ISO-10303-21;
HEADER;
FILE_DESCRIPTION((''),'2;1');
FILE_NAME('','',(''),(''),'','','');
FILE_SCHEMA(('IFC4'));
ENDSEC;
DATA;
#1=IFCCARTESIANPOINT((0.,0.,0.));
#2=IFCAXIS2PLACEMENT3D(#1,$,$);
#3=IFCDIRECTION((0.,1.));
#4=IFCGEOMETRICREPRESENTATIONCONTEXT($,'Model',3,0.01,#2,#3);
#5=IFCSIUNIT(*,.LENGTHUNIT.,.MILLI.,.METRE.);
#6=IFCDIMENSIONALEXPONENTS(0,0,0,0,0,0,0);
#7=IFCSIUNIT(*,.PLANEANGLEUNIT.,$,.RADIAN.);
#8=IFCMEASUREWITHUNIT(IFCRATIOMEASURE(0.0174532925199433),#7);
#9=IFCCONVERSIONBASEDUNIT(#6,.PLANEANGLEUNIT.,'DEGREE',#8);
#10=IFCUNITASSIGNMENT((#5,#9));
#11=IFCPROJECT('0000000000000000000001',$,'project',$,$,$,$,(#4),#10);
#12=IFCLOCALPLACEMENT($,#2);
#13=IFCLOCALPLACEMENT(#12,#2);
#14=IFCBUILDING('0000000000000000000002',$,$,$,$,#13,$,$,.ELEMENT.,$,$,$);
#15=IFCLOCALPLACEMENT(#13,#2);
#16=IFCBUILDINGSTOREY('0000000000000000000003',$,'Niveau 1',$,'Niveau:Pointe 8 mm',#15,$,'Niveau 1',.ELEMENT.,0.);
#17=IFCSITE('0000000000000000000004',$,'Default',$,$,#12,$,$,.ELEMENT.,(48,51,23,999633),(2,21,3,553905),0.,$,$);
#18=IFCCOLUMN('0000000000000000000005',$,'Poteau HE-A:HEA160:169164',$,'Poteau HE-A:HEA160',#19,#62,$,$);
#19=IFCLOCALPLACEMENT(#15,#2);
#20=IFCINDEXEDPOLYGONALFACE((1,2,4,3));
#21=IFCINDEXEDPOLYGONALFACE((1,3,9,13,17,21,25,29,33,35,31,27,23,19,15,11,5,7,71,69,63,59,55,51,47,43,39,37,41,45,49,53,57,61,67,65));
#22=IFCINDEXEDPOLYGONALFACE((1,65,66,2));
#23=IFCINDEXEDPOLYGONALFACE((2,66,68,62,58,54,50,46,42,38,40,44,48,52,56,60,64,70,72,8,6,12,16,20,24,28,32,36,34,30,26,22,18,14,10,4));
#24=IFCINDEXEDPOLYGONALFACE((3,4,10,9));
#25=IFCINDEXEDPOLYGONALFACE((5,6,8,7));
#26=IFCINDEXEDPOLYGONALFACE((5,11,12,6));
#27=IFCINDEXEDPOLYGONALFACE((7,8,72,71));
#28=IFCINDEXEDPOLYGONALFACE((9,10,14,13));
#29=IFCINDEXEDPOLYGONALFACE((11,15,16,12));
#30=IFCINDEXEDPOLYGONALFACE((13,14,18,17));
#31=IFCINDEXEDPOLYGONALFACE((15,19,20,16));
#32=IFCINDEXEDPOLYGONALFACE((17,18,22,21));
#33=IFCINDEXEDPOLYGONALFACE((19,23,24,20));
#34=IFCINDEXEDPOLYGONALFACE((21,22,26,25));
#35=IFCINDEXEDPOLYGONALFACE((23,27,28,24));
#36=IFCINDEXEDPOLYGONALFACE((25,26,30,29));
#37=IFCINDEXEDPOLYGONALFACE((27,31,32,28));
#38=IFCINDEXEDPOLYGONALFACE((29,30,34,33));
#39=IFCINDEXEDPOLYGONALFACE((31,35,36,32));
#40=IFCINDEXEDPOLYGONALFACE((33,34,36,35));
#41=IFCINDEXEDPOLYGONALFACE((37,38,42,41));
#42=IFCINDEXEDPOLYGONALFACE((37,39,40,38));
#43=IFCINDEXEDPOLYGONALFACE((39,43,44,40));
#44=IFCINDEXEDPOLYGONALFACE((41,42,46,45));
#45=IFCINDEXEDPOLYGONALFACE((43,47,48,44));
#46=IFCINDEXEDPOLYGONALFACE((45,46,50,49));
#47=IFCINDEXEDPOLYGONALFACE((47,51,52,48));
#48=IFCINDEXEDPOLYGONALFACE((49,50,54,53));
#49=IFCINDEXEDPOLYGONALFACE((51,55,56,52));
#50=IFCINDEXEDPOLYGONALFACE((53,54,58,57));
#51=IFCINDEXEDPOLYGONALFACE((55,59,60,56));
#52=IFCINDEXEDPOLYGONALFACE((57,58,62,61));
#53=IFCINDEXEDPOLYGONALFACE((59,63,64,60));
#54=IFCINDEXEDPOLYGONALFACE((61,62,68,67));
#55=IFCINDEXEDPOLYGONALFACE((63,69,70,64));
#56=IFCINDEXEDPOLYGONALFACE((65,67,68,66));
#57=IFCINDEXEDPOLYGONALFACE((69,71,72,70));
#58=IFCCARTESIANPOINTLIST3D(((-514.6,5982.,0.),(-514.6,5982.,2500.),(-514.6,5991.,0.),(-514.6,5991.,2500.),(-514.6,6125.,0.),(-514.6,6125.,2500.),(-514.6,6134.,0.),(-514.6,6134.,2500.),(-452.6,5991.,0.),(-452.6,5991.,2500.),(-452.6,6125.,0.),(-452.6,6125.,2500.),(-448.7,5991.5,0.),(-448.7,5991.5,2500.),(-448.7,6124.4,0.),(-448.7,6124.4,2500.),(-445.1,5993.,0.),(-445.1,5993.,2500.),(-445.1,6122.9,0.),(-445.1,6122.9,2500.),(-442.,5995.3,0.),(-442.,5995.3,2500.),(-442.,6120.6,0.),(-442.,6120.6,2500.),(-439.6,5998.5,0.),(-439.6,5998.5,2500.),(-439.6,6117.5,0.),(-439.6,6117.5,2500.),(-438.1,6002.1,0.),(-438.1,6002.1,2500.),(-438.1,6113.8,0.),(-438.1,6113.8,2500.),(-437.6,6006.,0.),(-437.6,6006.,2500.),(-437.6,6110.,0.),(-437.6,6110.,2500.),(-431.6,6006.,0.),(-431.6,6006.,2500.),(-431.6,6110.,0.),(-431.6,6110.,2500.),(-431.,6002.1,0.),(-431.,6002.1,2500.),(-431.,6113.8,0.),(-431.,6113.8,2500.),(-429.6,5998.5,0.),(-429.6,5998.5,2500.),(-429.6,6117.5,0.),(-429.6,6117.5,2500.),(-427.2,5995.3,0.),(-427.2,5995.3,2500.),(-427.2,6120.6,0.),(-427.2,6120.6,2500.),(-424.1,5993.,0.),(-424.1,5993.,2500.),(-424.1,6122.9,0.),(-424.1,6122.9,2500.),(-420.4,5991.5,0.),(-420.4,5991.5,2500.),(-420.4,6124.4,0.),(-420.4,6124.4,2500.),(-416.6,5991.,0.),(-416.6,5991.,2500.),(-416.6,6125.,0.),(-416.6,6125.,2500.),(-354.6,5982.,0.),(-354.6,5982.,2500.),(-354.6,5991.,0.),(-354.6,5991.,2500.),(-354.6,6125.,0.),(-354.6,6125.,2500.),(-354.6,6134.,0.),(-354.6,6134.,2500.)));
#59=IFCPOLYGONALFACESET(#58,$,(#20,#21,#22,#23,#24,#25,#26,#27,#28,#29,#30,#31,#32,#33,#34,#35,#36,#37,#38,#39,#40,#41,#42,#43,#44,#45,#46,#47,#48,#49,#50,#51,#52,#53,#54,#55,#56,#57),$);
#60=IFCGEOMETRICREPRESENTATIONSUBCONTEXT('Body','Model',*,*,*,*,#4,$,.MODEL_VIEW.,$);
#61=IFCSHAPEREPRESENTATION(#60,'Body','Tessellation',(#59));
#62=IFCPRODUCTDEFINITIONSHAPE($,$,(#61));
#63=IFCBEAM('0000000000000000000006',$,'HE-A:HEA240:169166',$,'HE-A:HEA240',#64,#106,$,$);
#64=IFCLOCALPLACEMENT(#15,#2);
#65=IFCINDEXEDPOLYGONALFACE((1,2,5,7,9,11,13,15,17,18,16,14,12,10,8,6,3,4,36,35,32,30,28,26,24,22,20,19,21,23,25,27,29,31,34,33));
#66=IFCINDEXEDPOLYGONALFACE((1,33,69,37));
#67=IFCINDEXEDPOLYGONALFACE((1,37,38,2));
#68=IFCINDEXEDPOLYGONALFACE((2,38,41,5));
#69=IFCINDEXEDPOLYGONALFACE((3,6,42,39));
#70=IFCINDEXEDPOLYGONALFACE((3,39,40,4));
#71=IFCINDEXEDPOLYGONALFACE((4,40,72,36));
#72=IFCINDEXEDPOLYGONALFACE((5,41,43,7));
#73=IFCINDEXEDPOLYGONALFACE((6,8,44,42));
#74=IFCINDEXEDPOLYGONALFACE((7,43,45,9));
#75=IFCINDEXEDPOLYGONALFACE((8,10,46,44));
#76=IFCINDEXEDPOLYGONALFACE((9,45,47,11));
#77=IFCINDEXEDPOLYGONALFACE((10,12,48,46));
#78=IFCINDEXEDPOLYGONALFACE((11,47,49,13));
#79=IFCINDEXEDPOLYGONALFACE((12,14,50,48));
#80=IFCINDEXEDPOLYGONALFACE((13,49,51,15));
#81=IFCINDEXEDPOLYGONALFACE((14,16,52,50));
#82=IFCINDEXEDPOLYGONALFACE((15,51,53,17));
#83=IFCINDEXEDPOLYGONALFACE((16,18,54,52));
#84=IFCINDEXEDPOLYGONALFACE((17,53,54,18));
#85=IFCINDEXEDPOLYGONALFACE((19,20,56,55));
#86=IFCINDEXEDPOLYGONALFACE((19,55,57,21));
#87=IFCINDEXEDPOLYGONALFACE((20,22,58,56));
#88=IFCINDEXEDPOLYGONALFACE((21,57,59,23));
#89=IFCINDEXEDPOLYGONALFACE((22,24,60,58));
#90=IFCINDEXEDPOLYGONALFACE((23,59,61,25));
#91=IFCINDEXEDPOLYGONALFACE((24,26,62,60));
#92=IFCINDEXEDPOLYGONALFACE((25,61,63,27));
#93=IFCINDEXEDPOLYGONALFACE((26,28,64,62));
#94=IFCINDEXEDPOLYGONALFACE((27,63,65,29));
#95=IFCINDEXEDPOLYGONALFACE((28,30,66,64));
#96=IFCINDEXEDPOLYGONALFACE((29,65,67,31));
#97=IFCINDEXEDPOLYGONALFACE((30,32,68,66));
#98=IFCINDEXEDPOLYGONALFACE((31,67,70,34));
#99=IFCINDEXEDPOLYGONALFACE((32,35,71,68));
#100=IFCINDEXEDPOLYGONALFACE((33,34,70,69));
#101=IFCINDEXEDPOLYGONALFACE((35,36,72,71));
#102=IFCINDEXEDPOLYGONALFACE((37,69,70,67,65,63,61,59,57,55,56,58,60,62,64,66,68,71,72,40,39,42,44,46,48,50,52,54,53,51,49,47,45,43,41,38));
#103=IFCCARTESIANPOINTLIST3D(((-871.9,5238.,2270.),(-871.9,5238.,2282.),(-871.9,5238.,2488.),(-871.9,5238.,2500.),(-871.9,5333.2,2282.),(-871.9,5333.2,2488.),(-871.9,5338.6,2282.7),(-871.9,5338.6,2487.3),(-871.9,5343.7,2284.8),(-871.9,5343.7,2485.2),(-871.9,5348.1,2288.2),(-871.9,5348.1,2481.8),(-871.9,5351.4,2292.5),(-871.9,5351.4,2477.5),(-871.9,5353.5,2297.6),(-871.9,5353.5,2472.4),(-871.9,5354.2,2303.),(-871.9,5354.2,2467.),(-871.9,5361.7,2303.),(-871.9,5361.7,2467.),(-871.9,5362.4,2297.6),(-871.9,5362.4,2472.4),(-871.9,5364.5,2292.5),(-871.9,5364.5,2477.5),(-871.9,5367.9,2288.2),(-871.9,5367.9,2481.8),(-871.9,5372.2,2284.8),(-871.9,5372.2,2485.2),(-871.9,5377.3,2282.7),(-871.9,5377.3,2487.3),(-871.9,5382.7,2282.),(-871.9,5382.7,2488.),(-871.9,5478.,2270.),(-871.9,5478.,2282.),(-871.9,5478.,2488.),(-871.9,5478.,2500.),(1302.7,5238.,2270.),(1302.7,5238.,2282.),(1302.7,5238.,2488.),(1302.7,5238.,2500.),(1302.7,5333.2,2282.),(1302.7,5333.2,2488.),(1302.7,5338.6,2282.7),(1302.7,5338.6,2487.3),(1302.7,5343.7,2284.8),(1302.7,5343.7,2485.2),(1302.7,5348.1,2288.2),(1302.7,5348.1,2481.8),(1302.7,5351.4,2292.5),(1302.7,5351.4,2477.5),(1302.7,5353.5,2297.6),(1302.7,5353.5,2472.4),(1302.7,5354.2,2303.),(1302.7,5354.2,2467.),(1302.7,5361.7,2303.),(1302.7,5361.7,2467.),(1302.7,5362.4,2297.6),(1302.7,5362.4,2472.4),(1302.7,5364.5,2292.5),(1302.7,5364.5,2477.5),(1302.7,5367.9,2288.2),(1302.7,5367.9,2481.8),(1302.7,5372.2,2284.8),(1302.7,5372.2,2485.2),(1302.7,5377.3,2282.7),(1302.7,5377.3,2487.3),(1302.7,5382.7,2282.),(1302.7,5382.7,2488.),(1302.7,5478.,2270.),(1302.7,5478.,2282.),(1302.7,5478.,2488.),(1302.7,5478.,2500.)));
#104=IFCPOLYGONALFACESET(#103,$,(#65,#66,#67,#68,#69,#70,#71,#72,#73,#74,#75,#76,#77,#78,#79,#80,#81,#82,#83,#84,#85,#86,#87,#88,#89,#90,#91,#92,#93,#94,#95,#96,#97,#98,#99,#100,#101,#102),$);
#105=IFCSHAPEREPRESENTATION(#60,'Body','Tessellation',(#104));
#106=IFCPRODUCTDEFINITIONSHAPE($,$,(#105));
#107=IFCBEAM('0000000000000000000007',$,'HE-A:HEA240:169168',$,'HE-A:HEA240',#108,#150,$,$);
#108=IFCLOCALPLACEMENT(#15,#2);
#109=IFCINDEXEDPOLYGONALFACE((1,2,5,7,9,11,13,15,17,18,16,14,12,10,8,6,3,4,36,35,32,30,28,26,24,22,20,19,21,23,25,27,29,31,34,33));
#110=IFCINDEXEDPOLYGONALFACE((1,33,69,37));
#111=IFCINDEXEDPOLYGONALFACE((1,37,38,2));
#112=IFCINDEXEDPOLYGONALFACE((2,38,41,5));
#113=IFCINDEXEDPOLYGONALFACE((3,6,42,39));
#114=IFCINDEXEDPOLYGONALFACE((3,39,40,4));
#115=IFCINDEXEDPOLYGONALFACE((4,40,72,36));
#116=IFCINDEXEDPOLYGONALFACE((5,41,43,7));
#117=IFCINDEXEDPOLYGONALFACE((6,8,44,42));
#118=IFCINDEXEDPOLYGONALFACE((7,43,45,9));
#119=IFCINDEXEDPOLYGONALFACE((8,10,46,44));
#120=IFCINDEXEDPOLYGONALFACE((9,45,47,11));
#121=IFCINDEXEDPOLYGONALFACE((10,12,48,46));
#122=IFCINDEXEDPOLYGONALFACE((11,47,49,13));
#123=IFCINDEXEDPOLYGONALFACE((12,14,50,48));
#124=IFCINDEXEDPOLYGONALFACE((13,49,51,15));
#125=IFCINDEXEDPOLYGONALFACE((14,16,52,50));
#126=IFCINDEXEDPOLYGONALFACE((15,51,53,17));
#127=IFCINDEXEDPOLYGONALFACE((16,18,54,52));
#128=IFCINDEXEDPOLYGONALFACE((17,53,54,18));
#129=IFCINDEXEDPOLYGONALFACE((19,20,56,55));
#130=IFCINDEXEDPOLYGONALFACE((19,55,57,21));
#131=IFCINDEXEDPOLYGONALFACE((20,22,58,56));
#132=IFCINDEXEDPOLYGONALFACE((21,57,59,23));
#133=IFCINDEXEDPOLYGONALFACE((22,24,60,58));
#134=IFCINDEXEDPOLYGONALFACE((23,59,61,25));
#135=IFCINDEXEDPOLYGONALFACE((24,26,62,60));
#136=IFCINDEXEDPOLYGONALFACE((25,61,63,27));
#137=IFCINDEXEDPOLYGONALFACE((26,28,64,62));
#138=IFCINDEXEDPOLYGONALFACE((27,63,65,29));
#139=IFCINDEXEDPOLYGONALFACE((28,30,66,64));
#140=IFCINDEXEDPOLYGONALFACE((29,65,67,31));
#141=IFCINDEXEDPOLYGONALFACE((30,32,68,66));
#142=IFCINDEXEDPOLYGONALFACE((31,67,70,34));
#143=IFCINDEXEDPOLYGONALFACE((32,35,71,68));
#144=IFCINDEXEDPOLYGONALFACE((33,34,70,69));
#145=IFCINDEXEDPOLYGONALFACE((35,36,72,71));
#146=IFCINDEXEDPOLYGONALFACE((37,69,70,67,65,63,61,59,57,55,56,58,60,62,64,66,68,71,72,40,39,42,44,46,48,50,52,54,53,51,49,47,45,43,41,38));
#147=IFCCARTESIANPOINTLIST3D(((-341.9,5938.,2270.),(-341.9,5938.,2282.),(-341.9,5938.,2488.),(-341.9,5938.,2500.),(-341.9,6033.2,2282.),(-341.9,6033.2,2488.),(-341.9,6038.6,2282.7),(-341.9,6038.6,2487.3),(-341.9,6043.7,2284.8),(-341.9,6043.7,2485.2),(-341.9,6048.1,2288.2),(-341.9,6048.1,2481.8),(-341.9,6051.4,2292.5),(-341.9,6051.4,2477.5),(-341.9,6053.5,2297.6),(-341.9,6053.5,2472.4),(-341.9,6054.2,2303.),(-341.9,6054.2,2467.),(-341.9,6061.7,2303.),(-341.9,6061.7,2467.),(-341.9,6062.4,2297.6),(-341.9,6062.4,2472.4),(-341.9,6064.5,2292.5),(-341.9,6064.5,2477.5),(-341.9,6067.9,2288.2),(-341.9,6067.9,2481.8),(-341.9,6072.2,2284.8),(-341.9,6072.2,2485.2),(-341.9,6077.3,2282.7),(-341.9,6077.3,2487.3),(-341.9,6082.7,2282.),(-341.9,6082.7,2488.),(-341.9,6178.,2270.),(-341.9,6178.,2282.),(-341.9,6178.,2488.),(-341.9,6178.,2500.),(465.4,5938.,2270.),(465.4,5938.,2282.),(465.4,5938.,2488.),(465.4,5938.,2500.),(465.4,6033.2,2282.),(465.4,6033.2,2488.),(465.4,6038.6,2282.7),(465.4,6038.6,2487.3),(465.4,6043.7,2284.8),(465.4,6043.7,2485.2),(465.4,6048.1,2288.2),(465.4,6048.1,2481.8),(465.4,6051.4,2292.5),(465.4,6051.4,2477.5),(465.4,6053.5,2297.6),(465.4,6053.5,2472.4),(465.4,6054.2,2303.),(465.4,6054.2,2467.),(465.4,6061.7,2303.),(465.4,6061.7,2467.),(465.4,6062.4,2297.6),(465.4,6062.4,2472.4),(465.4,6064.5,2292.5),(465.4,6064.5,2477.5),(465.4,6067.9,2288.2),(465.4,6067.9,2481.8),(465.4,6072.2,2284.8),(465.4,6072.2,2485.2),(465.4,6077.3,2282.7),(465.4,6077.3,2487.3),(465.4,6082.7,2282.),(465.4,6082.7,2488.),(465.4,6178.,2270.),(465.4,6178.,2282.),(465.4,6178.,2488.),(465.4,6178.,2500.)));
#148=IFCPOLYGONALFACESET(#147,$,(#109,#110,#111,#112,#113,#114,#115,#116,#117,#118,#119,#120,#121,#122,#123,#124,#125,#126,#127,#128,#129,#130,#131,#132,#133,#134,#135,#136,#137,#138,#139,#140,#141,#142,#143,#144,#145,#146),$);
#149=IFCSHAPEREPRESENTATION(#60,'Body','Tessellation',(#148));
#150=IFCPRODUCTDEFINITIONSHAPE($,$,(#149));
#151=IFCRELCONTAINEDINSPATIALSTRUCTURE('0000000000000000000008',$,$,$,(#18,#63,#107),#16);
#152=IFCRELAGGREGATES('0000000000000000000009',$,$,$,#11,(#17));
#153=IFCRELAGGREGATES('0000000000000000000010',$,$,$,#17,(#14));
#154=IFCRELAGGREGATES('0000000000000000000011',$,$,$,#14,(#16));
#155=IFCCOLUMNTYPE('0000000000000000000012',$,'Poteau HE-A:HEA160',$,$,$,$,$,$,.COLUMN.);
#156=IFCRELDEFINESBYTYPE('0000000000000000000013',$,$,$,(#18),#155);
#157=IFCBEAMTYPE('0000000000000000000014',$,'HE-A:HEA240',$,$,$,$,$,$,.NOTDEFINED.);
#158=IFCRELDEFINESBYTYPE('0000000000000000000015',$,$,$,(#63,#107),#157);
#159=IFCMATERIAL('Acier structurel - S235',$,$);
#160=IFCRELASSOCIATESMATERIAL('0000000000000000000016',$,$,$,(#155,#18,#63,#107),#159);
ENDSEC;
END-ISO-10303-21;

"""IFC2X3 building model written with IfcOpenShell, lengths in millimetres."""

from ifc_helpers import new_model, entity, si_unit, converted_unit, direction, frame, frame_2d, origin, place, context, subcontext, project, spatial, polyline, circle_curve, parameter, trimmed, segment, composite_curve, i_section, outline, extrude, source, transform, mapped, material, type_object, type_shapes, element, save


model = new_model("IFC2X3")

# Units and contexts
model_context = context("Model", 3, precision=0.01, world=origin(), true_north=direction((0.0, 1.0)))
body_context = subcontext(model_context, "Body", "Model", "MODEL_VIEW")
ifc_project = project(units=[si_unit("LENGTHUNIT", "METRE", prefix="MILLI"), converted_unit("PLANEANGLEUNIT", "DEGREE", entity("IfcRatioMeasure", 0.0174532925199433), si_unit("PLANEANGLEUNIT", "RADIAN"), dimensions=[0, 0, 0, 0, 0, 0, 0])], contexts=[model_context])

# Site, building, storey
site_placement = place(None, origin())
site = spatial("IfcSite", under=ifc_project, at=site_placement, Name="Default", CompositionType="ELEMENT", RefLatitude=(48, 51, 23, 999633), RefLongitude=(2, 21, 3, 553905), RefElevation=0.0)
building_placement = place(site_placement, origin())
building = spatial("IfcBuilding", under=site, at=building_placement, CompositionType="ELEMENT")
storey_placement = place(building_placement, origin())
storey = spatial("IfcBuildingStorey", under=building, at=storey_placement, Name="Niveau 1", ObjectType="Niveau:Pointe 8 mm", LongName="Niveau 1", CompositionType="ELEMENT", Elevation=0.0)

# Column
ifc_material_1 = material(Name="Acier structurel - S235")
column_type_1 = type_object("IfcColumnType", Name="Poteau HE-A:HEA160", PredefinedType="COLUMN", material=ifc_material_1)
shared_shape_1 = source(origin(), body_context, "Body", "SweptSolid", [
    extrude(outline(composite_curve([segment(polyline([(67.0, -80.0), (76.0, -80.0)]), True, "CONTINUOUS"), segment(polyline([(76.0, -80.0), (76.0, 80.0)]), True, "CONTINUOUS"), segment(polyline([(76.0, 80.0), (67.0, 80.0)]), True, "CONTINUOUS"), segment(polyline([(67.0, 80.0), (67.0, 18.0)]), True, "CONTINUOUS"), segment(trimmed(circle_curve(frame_2d((52.0, 18.0), x_axis=(1.0, 0.0)), 15.0), [parameter(270.0)], [parameter(0.0)], True, "PARAMETER"), False, "CONTINUOUS"), segment(polyline([(52.0, 3.0), (-52.0, 3.0)]), True, "CONTINUOUS"), segment(trimmed(circle_curve(frame_2d((-52.0, 18.0), x_axis=(0.0, -1.0)), 15.0), [parameter(270.0)], [parameter(0.0)], True, "PARAMETER"), False, "CONTINUOUS"), segment(polyline([(-67.0, 18.0), (-67.0, 80.0)]), True, "CONTINUOUS"), segment(polyline([(-67.0, 80.0), (-76.0, 80.0)]), True, "CONTINUOUS"), segment(polyline([(-76.0, 80.0), (-76.0, -80.0)]), True, "CONTINUOUS"), segment(polyline([(-76.0, -80.0), (-67.0, -80.0)]), True, "CONTINUOUS"), segment(polyline([(-67.0, -80.0), (-67.0, -18.0)]), True, "CONTINUOUS"), segment(trimmed(circle_curve(frame_2d((-52.0, -18.0), x_axis=(-1.0, 0.0)), 15.0), [parameter(270.0)], [parameter(0.0)], True, "PARAMETER"), False, "CONTINUOUS"), segment(polyline([(-52.0, -3.0), (52.0, -3.0)]), True, "CONTINUOUS"), segment(trimmed(circle_curve(frame_2d((52.0, -18.0), x_axis=(0.0, 1.0)), 15.0), [parameter(270.0)], [parameter(0.0)], True, "PARAMETER"), False, "CONTINUOUS"), segment(polyline([(67.0, -18.0), (67.0, -80.0)]), True, "CONTINUOUS")], self_intersect=False)), frame((0.0, 0.0, 0.0), z_axis=(0.0, 0.0, 1.0), x_axis=(0.0, -1.0, 0.0)), (0.0, 0.0, 1.0), 2500.0),
])
type_shapes(column_type_1, [shared_shape_1])
column_placement = place(storey_placement, frame((-434.6, 6058.0, 0.0)))
element("IfcColumn", 1, at=column_placement, inside=storey, type_object=column_type_1, material=ifc_material_1, Name="Poteau HE-A:HEA160:169164", ObjectType="Poteau HE-A:HEA160", context=body_context, shape_type="MappedRepresentation", body=[
    mapped(shared_shape_1, transform((0.0, 0.0, 0.0), scale=1.0)),
])

# Beams
beam_type = type_object("IfcBeamType", Name="HE-A:HEA240", PredefinedType="NOTDEFINED")
beam_1_placement = place(storey_placement, frame((-1034.6, 5358.0, 2500.0)))
element("IfcBeam", 2, at=beam_1_placement, inside=storey, type_object=beam_type, material=ifc_material_1, Name="HE-A:HEA240:169166", ObjectType="HE-A:HEA240", context=body_context, shape_type="SweptSolid", body=[
    extrude(i_section(OverallWidth=240.0, OverallDepth=230.0, WebThickness=7.5, FlangeThickness=12.0, FilletRadius=21.0, at=frame_2d((0.0, 0.0), x_axis=(0.0, 1.0))), frame((162.7, 0.0, -115.0), z_axis=(1.0, 0.0, 0.0), x_axis=(0.0, 0.0, -1.0)), (0.0, 0.0, 1.0), 2174.6),
])
beam_2_placement = place(storey_placement, frame((-434.6, 6058.0, 2500.0)))
element("IfcBeam", 3, at=beam_2_placement, inside=storey, type_object=beam_type, material=ifc_material_1, Name="HE-A:HEA240:169168", ObjectType="HE-A:HEA240", context=body_context, shape_type="SweptSolid", body=[
    extrude(i_section(OverallWidth=240.0, OverallDepth=230.0, WebThickness=7.5, FlangeThickness=12.0, FilletRadius=21.0, at=frame_2d((0.0, 0.0), x_axis=(0.0, 1.0))), frame((92.7, 0.0, -115.0), z_axis=(1.0, 0.0, 0.0), x_axis=(0.0, 0.0, -1.0)), (0.0, 0.0, 1.0), 807.3),
])

save(model, "model.ifc")
